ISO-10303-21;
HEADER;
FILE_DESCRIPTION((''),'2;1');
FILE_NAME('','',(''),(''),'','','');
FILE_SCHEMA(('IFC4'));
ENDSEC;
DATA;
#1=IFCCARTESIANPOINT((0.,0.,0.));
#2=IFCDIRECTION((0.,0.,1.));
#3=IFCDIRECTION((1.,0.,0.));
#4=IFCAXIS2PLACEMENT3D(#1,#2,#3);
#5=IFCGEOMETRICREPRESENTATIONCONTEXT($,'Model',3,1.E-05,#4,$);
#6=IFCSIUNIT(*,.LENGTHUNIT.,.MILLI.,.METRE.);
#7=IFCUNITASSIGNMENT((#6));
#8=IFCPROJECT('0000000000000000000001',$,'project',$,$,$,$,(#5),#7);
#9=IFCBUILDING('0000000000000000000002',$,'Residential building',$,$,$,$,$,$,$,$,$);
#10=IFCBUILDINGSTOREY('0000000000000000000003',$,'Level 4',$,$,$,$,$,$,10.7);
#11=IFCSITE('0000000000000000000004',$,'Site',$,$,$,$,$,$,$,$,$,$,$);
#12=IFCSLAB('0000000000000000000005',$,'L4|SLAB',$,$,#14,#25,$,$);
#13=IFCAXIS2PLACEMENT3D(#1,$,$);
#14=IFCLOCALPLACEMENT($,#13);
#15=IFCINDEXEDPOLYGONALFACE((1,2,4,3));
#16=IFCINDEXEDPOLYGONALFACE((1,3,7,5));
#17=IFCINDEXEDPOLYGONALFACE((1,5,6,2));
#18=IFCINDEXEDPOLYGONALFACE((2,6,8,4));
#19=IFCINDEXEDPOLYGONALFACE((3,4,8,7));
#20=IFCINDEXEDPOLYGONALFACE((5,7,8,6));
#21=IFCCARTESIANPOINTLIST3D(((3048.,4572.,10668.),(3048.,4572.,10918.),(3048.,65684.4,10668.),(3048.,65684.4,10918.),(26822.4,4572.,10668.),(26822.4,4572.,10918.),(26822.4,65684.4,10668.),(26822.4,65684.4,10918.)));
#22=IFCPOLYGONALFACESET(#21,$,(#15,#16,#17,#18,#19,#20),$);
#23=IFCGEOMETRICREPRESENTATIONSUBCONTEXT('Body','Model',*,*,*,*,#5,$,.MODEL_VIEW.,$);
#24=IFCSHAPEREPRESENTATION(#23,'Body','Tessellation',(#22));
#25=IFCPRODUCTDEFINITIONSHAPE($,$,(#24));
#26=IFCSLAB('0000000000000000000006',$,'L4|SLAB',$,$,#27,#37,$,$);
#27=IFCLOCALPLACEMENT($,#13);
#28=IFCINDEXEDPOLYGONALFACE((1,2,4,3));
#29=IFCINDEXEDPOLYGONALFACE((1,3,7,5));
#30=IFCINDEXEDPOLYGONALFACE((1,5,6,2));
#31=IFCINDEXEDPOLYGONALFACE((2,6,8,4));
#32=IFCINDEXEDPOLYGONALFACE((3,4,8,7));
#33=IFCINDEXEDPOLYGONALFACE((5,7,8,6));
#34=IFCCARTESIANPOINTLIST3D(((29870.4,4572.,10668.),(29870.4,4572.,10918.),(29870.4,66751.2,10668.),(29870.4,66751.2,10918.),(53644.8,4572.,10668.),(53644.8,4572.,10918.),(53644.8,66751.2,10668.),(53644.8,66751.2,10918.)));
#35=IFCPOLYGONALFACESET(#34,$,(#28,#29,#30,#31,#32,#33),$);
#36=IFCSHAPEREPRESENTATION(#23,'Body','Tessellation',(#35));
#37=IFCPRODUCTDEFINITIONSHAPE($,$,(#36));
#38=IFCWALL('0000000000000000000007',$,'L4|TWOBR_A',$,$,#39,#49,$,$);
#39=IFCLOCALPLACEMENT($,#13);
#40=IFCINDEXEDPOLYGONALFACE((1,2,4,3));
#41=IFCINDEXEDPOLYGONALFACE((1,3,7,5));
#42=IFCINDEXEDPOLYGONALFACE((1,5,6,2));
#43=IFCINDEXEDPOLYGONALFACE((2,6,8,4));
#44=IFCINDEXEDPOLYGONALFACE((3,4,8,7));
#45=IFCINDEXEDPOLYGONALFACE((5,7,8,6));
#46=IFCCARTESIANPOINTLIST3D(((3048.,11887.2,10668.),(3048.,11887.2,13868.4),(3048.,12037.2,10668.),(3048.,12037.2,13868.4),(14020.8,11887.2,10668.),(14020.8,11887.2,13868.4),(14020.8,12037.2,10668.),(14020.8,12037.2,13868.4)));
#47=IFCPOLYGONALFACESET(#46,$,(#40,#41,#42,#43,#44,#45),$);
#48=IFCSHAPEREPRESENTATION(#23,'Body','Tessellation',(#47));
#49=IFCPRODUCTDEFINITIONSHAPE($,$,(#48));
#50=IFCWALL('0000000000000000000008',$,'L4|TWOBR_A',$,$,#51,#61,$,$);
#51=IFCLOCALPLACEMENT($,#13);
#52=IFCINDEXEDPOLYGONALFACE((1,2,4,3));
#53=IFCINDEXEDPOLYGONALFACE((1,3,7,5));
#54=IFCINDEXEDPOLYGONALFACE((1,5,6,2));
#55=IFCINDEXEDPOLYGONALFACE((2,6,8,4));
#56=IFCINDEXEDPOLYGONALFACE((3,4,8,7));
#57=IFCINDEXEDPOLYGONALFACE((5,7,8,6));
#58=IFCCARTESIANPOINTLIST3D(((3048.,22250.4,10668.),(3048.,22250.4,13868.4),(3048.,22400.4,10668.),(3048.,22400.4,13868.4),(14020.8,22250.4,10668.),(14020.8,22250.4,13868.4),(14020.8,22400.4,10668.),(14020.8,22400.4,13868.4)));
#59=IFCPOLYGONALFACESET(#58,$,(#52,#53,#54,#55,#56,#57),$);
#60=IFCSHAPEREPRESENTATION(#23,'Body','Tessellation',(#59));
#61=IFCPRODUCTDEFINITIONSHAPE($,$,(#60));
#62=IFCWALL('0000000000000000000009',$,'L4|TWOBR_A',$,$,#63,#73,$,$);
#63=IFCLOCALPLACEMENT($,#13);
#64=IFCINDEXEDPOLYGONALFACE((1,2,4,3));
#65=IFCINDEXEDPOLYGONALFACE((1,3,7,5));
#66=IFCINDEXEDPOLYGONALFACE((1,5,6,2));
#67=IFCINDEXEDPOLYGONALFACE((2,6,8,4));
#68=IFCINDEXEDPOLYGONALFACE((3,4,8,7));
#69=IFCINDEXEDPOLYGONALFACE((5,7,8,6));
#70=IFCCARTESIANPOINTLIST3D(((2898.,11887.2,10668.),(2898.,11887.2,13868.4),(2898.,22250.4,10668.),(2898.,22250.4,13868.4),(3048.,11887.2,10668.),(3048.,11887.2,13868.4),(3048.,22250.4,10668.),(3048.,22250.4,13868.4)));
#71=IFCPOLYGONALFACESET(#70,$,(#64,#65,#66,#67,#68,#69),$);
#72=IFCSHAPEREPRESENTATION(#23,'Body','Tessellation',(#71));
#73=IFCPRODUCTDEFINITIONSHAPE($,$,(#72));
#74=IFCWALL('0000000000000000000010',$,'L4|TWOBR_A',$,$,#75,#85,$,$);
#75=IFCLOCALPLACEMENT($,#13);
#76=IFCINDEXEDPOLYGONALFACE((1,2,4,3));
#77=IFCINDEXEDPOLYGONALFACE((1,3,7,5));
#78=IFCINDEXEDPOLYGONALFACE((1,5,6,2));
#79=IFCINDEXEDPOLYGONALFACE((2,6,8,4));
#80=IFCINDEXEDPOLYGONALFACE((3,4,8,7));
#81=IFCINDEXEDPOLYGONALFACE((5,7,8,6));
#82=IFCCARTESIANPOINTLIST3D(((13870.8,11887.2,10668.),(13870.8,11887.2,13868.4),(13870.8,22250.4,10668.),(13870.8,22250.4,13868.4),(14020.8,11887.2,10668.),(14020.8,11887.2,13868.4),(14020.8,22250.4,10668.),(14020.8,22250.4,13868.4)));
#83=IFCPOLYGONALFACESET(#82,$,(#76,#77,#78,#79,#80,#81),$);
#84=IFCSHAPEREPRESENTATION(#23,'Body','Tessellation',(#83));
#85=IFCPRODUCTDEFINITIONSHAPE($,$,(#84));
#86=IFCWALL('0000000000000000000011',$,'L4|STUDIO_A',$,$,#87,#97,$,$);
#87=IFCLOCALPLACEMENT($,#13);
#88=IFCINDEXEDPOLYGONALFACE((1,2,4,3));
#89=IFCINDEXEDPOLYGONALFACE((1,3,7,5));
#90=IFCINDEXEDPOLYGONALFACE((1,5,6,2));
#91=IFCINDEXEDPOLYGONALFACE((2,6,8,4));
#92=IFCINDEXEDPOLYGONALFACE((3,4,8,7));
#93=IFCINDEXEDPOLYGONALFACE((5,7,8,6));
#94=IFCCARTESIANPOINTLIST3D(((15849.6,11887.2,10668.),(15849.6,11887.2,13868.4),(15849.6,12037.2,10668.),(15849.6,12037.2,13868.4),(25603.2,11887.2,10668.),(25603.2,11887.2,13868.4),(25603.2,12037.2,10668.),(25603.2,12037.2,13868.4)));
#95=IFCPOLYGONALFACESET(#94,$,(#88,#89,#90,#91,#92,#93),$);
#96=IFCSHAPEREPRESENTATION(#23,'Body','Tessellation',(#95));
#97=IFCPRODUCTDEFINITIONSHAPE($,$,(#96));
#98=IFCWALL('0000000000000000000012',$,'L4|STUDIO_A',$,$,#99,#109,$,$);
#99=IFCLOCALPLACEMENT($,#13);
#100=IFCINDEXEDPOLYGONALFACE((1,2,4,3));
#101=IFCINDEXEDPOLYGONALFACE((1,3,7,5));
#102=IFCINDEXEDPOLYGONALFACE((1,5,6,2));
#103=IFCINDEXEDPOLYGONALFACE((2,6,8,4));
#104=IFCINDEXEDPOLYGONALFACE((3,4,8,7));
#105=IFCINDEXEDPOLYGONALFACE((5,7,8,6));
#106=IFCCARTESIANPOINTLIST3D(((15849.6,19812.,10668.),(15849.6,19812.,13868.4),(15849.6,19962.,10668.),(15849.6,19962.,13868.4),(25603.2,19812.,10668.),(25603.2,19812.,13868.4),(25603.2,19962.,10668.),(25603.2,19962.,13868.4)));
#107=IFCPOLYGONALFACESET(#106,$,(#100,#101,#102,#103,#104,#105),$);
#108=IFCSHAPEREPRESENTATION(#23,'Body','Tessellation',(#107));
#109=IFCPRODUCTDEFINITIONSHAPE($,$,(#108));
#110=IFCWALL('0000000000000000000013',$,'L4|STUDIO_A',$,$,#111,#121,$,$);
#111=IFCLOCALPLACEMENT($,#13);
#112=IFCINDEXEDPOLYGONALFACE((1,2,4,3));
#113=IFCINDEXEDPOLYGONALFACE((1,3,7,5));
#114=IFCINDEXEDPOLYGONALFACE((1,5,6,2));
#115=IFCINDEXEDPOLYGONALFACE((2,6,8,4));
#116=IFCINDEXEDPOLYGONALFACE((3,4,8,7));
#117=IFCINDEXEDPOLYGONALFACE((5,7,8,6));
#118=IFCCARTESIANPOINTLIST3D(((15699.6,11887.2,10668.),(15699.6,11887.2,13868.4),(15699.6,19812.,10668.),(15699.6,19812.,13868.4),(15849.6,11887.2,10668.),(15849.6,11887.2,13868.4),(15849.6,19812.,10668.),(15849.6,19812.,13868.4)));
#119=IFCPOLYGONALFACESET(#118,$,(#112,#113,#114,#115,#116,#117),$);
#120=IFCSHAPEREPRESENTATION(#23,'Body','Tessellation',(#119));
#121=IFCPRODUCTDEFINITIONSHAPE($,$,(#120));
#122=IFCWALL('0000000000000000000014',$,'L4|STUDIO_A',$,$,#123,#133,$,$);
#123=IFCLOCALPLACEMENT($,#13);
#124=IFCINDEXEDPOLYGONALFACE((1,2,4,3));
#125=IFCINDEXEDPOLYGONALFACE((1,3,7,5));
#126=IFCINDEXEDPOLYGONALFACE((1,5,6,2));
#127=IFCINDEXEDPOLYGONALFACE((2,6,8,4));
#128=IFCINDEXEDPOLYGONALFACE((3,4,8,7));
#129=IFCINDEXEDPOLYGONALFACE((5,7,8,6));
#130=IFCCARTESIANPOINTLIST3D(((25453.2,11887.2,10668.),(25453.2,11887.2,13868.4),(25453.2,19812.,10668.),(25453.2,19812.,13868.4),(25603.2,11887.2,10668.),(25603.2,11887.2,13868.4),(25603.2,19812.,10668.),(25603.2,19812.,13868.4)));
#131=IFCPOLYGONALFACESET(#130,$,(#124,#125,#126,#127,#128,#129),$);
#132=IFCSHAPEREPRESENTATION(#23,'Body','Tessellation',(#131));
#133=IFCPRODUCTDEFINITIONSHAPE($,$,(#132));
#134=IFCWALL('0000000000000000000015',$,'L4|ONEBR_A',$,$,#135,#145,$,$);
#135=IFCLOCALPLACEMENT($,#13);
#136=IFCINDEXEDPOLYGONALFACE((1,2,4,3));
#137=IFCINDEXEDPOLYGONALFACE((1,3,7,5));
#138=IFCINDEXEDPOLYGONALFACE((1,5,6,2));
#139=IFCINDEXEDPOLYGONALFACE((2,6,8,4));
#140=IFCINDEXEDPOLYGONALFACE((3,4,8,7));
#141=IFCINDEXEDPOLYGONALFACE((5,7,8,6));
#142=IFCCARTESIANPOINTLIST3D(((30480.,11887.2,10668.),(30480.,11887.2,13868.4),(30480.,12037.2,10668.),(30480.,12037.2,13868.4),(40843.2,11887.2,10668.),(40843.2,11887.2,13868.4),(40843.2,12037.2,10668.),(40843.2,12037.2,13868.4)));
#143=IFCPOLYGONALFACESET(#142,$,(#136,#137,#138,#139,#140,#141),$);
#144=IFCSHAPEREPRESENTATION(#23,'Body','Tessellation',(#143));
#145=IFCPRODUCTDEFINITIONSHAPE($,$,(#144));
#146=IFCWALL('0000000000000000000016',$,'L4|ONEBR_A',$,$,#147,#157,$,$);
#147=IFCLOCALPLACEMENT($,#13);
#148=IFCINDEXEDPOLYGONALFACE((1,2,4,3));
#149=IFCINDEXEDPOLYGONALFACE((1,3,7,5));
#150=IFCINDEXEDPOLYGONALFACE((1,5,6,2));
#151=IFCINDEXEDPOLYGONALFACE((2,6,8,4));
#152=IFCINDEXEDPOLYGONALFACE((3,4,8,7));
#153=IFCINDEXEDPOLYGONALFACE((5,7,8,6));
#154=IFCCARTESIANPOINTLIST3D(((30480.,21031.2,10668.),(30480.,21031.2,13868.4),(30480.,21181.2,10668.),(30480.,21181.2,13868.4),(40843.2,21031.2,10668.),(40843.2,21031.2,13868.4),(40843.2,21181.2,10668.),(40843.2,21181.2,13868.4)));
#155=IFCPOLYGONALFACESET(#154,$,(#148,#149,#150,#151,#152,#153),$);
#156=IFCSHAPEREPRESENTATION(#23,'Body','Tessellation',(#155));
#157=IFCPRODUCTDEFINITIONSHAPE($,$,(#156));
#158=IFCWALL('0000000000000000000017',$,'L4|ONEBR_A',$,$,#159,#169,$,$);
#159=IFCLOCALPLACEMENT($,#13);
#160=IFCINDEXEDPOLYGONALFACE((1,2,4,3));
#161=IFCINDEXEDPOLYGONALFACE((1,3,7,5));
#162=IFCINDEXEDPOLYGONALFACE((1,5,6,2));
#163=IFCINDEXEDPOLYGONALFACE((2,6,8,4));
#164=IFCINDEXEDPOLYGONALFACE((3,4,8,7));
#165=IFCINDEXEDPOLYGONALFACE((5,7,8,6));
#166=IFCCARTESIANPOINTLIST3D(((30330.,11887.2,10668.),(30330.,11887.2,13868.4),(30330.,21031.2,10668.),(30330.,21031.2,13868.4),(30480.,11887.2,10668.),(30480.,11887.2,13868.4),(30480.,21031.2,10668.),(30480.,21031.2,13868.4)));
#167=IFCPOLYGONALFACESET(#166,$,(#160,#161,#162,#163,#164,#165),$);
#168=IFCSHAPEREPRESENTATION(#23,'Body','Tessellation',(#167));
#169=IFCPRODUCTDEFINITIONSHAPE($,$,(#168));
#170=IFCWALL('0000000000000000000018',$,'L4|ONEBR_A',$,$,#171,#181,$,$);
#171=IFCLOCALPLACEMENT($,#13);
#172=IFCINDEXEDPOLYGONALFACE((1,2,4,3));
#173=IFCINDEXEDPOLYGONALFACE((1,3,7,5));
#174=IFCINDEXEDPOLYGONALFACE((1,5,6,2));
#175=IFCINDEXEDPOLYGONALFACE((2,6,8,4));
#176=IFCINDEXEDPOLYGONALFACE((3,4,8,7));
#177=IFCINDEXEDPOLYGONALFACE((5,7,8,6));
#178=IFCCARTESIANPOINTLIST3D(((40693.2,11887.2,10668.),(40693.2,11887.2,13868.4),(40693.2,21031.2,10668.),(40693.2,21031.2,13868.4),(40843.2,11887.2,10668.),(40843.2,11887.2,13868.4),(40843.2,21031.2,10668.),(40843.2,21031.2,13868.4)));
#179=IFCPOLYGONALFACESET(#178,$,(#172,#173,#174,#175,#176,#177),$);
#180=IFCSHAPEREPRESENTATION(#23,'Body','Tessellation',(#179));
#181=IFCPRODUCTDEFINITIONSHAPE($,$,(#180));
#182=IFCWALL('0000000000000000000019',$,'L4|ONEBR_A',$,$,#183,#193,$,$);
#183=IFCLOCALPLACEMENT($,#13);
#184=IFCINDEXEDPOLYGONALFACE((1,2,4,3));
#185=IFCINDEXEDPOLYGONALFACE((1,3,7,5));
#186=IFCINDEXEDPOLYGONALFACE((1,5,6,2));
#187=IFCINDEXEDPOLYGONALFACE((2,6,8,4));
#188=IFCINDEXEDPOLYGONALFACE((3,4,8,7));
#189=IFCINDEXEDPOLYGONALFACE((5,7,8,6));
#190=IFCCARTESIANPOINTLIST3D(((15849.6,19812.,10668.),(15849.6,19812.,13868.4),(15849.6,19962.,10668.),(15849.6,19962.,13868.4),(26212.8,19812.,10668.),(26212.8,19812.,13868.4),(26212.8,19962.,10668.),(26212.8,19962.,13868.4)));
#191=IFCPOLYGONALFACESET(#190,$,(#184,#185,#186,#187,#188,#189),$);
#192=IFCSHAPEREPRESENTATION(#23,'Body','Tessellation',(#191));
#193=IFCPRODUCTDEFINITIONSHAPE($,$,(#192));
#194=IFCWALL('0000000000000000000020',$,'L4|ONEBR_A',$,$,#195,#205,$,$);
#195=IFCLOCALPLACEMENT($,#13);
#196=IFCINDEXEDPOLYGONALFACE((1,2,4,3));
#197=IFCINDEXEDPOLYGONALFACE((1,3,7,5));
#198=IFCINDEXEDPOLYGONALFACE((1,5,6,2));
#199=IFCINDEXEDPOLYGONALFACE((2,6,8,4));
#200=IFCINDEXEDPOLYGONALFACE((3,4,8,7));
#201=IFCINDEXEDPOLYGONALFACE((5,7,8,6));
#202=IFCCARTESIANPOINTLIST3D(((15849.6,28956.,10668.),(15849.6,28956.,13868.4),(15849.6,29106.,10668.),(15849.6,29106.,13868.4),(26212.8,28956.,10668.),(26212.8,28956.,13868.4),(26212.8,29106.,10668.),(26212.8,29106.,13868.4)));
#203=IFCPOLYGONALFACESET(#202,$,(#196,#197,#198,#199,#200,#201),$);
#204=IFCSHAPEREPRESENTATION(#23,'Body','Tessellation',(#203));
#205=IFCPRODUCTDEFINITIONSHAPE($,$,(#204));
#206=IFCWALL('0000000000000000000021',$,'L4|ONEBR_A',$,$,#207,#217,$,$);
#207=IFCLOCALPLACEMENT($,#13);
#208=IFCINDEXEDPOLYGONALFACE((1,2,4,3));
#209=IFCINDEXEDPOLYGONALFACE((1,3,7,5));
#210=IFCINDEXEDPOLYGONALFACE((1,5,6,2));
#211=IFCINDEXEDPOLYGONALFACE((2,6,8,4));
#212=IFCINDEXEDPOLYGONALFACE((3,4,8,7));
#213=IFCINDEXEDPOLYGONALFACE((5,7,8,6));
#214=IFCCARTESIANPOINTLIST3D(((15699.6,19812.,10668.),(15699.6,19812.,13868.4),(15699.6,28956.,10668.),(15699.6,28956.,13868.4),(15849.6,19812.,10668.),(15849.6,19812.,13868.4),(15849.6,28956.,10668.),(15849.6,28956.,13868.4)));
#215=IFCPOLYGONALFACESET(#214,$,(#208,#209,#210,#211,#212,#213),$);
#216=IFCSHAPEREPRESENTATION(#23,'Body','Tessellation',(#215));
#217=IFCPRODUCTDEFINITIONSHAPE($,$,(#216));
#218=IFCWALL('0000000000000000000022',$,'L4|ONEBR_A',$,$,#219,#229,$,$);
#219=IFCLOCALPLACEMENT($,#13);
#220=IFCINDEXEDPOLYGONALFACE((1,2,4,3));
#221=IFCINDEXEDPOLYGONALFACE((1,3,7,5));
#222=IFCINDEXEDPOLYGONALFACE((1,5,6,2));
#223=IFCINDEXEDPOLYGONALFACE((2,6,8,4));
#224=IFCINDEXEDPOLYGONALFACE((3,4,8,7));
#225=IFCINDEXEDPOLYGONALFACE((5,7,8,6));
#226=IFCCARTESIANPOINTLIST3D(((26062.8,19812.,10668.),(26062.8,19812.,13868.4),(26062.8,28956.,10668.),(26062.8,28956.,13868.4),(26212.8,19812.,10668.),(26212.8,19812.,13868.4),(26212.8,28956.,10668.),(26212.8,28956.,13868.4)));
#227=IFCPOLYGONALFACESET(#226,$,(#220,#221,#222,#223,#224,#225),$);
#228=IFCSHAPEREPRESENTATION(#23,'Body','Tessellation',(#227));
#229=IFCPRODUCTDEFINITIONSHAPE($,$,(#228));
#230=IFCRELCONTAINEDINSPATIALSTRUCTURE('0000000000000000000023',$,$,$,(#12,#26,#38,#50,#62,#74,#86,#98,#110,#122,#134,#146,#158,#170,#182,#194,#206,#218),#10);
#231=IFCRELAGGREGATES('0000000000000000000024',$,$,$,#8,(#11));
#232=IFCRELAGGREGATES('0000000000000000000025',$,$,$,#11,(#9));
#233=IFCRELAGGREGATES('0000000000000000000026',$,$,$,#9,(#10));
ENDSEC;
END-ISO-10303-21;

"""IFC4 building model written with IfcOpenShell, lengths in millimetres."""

from ifc_helpers import new_model, si_unit, frame, origin_with_axes, place, context, subcontext, project, spatial, indexed_curve, outline, extrude, element, save


model = new_model("IFC4")

# Units and contexts
model_context = context("Model", 3, precision=1e-05, world=origin_with_axes())
body_context = subcontext(model_context, "Body", "Model", "MODEL_VIEW")
ifc_project = project(units=[si_unit("LENGTHUNIT", "METRE", prefix="MILLI")], contexts=[model_context])

# Site, building, storey
site = spatial("IfcSite", under=ifc_project, Name="Site")
building = spatial("IfcBuilding", under=site, Name="Residential building")
storey = spatial("IfcBuildingStorey", under=building, Name="Level 4", Elevation=10.7)

# Slabs
slab_1_placement = place(None, frame((3048.0, 4572.0, 10668.0), z_axis=(0.0, 0.0, 1.0), x_axis=(1.0, 0.0, 0.0)))
element("IfcSlab", 1, at=slab_1_placement, inside=storey, Name="L4|SLAB", context=body_context, shape_type="SweptSolid", body=[
    extrude(outline(indexed_curve([(0.0, 0.0), (23774.4, 0.0), (23774.4, 61112.4), (0.0, 61112.4), (0.0, 0.0)])), None, (0.0, 0.0, 1.0), 250.0),
])
slab_2_placement = place(None, frame((29870.4, 4572.0, 10668.0), z_axis=(0.0, 0.0, 1.0), x_axis=(1.0, 0.0, 0.0)))
element("IfcSlab", 2, at=slab_2_placement, inside=storey, Name="L4|SLAB", context=body_context, shape_type="SweptSolid", body=[
    extrude(outline(indexed_curve([(0.0, 0.0), (23774.4, 0.0), (23774.4, 62179.2), (0.0, 62179.2), (0.0, 0.0)])), None, (0.0, 0.0, 1.0), 250.0),
])

# Walls
for number, where, z_axis, x_axis, name in (
    (3, (3048.0, 11887.2, 10668.0), (0.0, 0.0, 1.0), (1.0, 0.0, 0.0), "L4|TWOBR_A"),
    (4, (3048.0, 22250.4, 10668.0), (0.0, 0.0, 1.0), (1.0, 0.0, 0.0), "L4|TWOBR_A"),
):
    element("IfcWall", number, at=place(None, frame(where, z_axis=z_axis, x_axis=x_axis)), inside=storey, Name=name, context=body_context, shape_type="SweptSolid", body=[
        extrude(outline(indexed_curve([(0.0, 0.0), (0.0, 150.0), (10972.8, 150.0), (10972.8, 0.0), (0.0, 0.0)], self_intersect=False)), origin_with_axes(), (0.0, 0.0, 1.0), 3200.4),
    ])
for number, where, z_axis, x_axis, name in (
    (5, (3048.0, 11887.2, 10668.0), (0.0, 0.0, 1.0), (0.0, 1.0, 0.0), "L4|TWOBR_A"),
    (6, (14020.8, 11887.2, 10668.0), (0.0, 0.0, 1.0), (0.0, 1.0, 0.0), "L4|TWOBR_A"),
):
    element("IfcWall", number, at=place(None, frame(where, z_axis=z_axis, x_axis=x_axis)), inside=storey, Name=name, context=body_context, shape_type="SweptSolid", body=[
        extrude(outline(indexed_curve([(0.0, 0.0), (0.0, 150.0), (10363.2, 150.0), (10363.2, 0.0), (0.0, 0.0)], self_intersect=False)), origin_with_axes(), (0.0, 0.0, 1.0), 3200.4),
    ])
for number, where, z_axis, x_axis, name in (
    (7, (15849.6, 11887.2, 10668.0), (0.0, 0.0, 1.0), (1.0, 0.0, 0.0), "L4|STUDIO_A"),
    (8, (15849.6, 19812.0, 10668.0), (0.0, 0.0, 1.0), (1.0, 0.0, 0.0), "L4|STUDIO_A"),
):
    element("IfcWall", number, at=place(None, frame(where, z_axis=z_axis, x_axis=x_axis)), inside=storey, Name=name, context=body_context, shape_type="SweptSolid", body=[
        extrude(outline(indexed_curve([(0.0, 0.0), (0.0, 150.0), (9753.6, 150.0), (9753.6, 0.0), (0.0, 0.0)], self_intersect=False)), origin_with_axes(), (0.0, 0.0, 1.0), 3200.4),
    ])
for number, where, z_axis, x_axis, name in (
    (9, (15849.6, 11887.2, 10668.0), (0.0, 0.0, 1.0), (0.0, 1.0, 0.0), "L4|STUDIO_A"),
    (10, (25603.2, 11887.2, 10668.0), (0.0, 0.0, 1.0), (0.0, 1.0, 0.0), "L4|STUDIO_A"),
):
    element("IfcWall", number, at=place(None, frame(where, z_axis=z_axis, x_axis=x_axis)), inside=storey, Name=name, context=body_context, shape_type="SweptSolid", body=[
        extrude(outline(indexed_curve([(0.0, 0.0), (0.0, 150.0), (7924.8, 150.0), (7924.8, 0.0), (0.0, 0.0)], self_intersect=False)), origin_with_axes(), (0.0, 0.0, 1.0), 3200.4),
    ])
for number, where, z_axis, x_axis, name in (
    (11, (30480.0, 11887.2, 10668.0), (0.0, 0.0, 1.0), (1.0, 0.0, 0.0), "L4|ONEBR_A"),
    (12, (30480.0, 21031.2, 10668.0), (0.0, 0.0, 1.0), (1.0, 0.0, 0.0), "L4|ONEBR_A"),
):
    element("IfcWall", number, at=place(None, frame(where, z_axis=z_axis, x_axis=x_axis)), inside=storey, Name=name, context=body_context, shape_type="SweptSolid", body=[
        extrude(outline(indexed_curve([(0.0, 0.0), (0.0, 150.0), (10363.2, 150.0), (10363.2, 0.0), (0.0, 0.0)], self_intersect=False)), origin_with_axes(), (0.0, 0.0, 1.0), 3200.4),
    ])
for number, where, z_axis, x_axis, name in (
    (13, (30480.0, 11887.2, 10668.0), (0.0, 0.0, 1.0), (0.0, 1.0, 0.0), "L4|ONEBR_A"),
    (14, (40843.2, 11887.2, 10668.0), (0.0, 0.0, 1.0), (0.0, 1.0, 0.0), "L4|ONEBR_A"),
):
    element("IfcWall", number, at=place(None, frame(where, z_axis=z_axis, x_axis=x_axis)), inside=storey, Name=name, context=body_context, shape_type="SweptSolid", body=[
        extrude(outline(indexed_curve([(0.0, 0.0), (0.0, 150.0), (9144.0, 150.0), (9144.0, 0.0), (0.0, 0.0)], self_intersect=False)), origin_with_axes(), (0.0, 0.0, 1.0), 3200.4),
    ])
for number, where, z_axis, x_axis, name in (
    (15, (15849.6, 19812.0, 10668.0), (0.0, 0.0, 1.0), (1.0, 0.0, 0.0), "L4|ONEBR_A"),
    (16, (15849.6, 28956.0, 10668.0), (0.0, 0.0, 1.0), (1.0, 0.0, 0.0), "L4|ONEBR_A"),
):
    element("IfcWall", number, at=place(None, frame(where, z_axis=z_axis, x_axis=x_axis)), inside=storey, Name=name, context=body_context, shape_type="SweptSolid", body=[
        extrude(outline(indexed_curve([(0.0, 0.0), (0.0, 150.0), (10363.2, 150.0), (10363.2, 0.0), (0.0, 0.0)], self_intersect=False)), origin_with_axes(), (0.0, 0.0, 1.0), 3200.4),
    ])
for number, where, z_axis, x_axis, name in (
    (17, (15849.6, 19812.0, 10668.0), (0.0, 0.0, 1.0), (0.0, 1.0, 0.0), "L4|ONEBR_A"),
    (18, (26212.8, 19812.0, 10668.0), (0.0, 0.0, 1.0), (0.0, 1.0, 0.0), "L4|ONEBR_A"),
):
    element("IfcWall", number, at=place(None, frame(where, z_axis=z_axis, x_axis=x_axis)), inside=storey, Name=name, context=body_context, shape_type="SweptSolid", body=[
        extrude(outline(indexed_curve([(0.0, 0.0), (0.0, 150.0), (9144.0, 150.0), (9144.0, 0.0), (0.0, 0.0)], self_intersect=False)), origin_with_axes(), (0.0, 0.0, 1.0), 3200.4),
    ])

save(model, "model.ifc")
